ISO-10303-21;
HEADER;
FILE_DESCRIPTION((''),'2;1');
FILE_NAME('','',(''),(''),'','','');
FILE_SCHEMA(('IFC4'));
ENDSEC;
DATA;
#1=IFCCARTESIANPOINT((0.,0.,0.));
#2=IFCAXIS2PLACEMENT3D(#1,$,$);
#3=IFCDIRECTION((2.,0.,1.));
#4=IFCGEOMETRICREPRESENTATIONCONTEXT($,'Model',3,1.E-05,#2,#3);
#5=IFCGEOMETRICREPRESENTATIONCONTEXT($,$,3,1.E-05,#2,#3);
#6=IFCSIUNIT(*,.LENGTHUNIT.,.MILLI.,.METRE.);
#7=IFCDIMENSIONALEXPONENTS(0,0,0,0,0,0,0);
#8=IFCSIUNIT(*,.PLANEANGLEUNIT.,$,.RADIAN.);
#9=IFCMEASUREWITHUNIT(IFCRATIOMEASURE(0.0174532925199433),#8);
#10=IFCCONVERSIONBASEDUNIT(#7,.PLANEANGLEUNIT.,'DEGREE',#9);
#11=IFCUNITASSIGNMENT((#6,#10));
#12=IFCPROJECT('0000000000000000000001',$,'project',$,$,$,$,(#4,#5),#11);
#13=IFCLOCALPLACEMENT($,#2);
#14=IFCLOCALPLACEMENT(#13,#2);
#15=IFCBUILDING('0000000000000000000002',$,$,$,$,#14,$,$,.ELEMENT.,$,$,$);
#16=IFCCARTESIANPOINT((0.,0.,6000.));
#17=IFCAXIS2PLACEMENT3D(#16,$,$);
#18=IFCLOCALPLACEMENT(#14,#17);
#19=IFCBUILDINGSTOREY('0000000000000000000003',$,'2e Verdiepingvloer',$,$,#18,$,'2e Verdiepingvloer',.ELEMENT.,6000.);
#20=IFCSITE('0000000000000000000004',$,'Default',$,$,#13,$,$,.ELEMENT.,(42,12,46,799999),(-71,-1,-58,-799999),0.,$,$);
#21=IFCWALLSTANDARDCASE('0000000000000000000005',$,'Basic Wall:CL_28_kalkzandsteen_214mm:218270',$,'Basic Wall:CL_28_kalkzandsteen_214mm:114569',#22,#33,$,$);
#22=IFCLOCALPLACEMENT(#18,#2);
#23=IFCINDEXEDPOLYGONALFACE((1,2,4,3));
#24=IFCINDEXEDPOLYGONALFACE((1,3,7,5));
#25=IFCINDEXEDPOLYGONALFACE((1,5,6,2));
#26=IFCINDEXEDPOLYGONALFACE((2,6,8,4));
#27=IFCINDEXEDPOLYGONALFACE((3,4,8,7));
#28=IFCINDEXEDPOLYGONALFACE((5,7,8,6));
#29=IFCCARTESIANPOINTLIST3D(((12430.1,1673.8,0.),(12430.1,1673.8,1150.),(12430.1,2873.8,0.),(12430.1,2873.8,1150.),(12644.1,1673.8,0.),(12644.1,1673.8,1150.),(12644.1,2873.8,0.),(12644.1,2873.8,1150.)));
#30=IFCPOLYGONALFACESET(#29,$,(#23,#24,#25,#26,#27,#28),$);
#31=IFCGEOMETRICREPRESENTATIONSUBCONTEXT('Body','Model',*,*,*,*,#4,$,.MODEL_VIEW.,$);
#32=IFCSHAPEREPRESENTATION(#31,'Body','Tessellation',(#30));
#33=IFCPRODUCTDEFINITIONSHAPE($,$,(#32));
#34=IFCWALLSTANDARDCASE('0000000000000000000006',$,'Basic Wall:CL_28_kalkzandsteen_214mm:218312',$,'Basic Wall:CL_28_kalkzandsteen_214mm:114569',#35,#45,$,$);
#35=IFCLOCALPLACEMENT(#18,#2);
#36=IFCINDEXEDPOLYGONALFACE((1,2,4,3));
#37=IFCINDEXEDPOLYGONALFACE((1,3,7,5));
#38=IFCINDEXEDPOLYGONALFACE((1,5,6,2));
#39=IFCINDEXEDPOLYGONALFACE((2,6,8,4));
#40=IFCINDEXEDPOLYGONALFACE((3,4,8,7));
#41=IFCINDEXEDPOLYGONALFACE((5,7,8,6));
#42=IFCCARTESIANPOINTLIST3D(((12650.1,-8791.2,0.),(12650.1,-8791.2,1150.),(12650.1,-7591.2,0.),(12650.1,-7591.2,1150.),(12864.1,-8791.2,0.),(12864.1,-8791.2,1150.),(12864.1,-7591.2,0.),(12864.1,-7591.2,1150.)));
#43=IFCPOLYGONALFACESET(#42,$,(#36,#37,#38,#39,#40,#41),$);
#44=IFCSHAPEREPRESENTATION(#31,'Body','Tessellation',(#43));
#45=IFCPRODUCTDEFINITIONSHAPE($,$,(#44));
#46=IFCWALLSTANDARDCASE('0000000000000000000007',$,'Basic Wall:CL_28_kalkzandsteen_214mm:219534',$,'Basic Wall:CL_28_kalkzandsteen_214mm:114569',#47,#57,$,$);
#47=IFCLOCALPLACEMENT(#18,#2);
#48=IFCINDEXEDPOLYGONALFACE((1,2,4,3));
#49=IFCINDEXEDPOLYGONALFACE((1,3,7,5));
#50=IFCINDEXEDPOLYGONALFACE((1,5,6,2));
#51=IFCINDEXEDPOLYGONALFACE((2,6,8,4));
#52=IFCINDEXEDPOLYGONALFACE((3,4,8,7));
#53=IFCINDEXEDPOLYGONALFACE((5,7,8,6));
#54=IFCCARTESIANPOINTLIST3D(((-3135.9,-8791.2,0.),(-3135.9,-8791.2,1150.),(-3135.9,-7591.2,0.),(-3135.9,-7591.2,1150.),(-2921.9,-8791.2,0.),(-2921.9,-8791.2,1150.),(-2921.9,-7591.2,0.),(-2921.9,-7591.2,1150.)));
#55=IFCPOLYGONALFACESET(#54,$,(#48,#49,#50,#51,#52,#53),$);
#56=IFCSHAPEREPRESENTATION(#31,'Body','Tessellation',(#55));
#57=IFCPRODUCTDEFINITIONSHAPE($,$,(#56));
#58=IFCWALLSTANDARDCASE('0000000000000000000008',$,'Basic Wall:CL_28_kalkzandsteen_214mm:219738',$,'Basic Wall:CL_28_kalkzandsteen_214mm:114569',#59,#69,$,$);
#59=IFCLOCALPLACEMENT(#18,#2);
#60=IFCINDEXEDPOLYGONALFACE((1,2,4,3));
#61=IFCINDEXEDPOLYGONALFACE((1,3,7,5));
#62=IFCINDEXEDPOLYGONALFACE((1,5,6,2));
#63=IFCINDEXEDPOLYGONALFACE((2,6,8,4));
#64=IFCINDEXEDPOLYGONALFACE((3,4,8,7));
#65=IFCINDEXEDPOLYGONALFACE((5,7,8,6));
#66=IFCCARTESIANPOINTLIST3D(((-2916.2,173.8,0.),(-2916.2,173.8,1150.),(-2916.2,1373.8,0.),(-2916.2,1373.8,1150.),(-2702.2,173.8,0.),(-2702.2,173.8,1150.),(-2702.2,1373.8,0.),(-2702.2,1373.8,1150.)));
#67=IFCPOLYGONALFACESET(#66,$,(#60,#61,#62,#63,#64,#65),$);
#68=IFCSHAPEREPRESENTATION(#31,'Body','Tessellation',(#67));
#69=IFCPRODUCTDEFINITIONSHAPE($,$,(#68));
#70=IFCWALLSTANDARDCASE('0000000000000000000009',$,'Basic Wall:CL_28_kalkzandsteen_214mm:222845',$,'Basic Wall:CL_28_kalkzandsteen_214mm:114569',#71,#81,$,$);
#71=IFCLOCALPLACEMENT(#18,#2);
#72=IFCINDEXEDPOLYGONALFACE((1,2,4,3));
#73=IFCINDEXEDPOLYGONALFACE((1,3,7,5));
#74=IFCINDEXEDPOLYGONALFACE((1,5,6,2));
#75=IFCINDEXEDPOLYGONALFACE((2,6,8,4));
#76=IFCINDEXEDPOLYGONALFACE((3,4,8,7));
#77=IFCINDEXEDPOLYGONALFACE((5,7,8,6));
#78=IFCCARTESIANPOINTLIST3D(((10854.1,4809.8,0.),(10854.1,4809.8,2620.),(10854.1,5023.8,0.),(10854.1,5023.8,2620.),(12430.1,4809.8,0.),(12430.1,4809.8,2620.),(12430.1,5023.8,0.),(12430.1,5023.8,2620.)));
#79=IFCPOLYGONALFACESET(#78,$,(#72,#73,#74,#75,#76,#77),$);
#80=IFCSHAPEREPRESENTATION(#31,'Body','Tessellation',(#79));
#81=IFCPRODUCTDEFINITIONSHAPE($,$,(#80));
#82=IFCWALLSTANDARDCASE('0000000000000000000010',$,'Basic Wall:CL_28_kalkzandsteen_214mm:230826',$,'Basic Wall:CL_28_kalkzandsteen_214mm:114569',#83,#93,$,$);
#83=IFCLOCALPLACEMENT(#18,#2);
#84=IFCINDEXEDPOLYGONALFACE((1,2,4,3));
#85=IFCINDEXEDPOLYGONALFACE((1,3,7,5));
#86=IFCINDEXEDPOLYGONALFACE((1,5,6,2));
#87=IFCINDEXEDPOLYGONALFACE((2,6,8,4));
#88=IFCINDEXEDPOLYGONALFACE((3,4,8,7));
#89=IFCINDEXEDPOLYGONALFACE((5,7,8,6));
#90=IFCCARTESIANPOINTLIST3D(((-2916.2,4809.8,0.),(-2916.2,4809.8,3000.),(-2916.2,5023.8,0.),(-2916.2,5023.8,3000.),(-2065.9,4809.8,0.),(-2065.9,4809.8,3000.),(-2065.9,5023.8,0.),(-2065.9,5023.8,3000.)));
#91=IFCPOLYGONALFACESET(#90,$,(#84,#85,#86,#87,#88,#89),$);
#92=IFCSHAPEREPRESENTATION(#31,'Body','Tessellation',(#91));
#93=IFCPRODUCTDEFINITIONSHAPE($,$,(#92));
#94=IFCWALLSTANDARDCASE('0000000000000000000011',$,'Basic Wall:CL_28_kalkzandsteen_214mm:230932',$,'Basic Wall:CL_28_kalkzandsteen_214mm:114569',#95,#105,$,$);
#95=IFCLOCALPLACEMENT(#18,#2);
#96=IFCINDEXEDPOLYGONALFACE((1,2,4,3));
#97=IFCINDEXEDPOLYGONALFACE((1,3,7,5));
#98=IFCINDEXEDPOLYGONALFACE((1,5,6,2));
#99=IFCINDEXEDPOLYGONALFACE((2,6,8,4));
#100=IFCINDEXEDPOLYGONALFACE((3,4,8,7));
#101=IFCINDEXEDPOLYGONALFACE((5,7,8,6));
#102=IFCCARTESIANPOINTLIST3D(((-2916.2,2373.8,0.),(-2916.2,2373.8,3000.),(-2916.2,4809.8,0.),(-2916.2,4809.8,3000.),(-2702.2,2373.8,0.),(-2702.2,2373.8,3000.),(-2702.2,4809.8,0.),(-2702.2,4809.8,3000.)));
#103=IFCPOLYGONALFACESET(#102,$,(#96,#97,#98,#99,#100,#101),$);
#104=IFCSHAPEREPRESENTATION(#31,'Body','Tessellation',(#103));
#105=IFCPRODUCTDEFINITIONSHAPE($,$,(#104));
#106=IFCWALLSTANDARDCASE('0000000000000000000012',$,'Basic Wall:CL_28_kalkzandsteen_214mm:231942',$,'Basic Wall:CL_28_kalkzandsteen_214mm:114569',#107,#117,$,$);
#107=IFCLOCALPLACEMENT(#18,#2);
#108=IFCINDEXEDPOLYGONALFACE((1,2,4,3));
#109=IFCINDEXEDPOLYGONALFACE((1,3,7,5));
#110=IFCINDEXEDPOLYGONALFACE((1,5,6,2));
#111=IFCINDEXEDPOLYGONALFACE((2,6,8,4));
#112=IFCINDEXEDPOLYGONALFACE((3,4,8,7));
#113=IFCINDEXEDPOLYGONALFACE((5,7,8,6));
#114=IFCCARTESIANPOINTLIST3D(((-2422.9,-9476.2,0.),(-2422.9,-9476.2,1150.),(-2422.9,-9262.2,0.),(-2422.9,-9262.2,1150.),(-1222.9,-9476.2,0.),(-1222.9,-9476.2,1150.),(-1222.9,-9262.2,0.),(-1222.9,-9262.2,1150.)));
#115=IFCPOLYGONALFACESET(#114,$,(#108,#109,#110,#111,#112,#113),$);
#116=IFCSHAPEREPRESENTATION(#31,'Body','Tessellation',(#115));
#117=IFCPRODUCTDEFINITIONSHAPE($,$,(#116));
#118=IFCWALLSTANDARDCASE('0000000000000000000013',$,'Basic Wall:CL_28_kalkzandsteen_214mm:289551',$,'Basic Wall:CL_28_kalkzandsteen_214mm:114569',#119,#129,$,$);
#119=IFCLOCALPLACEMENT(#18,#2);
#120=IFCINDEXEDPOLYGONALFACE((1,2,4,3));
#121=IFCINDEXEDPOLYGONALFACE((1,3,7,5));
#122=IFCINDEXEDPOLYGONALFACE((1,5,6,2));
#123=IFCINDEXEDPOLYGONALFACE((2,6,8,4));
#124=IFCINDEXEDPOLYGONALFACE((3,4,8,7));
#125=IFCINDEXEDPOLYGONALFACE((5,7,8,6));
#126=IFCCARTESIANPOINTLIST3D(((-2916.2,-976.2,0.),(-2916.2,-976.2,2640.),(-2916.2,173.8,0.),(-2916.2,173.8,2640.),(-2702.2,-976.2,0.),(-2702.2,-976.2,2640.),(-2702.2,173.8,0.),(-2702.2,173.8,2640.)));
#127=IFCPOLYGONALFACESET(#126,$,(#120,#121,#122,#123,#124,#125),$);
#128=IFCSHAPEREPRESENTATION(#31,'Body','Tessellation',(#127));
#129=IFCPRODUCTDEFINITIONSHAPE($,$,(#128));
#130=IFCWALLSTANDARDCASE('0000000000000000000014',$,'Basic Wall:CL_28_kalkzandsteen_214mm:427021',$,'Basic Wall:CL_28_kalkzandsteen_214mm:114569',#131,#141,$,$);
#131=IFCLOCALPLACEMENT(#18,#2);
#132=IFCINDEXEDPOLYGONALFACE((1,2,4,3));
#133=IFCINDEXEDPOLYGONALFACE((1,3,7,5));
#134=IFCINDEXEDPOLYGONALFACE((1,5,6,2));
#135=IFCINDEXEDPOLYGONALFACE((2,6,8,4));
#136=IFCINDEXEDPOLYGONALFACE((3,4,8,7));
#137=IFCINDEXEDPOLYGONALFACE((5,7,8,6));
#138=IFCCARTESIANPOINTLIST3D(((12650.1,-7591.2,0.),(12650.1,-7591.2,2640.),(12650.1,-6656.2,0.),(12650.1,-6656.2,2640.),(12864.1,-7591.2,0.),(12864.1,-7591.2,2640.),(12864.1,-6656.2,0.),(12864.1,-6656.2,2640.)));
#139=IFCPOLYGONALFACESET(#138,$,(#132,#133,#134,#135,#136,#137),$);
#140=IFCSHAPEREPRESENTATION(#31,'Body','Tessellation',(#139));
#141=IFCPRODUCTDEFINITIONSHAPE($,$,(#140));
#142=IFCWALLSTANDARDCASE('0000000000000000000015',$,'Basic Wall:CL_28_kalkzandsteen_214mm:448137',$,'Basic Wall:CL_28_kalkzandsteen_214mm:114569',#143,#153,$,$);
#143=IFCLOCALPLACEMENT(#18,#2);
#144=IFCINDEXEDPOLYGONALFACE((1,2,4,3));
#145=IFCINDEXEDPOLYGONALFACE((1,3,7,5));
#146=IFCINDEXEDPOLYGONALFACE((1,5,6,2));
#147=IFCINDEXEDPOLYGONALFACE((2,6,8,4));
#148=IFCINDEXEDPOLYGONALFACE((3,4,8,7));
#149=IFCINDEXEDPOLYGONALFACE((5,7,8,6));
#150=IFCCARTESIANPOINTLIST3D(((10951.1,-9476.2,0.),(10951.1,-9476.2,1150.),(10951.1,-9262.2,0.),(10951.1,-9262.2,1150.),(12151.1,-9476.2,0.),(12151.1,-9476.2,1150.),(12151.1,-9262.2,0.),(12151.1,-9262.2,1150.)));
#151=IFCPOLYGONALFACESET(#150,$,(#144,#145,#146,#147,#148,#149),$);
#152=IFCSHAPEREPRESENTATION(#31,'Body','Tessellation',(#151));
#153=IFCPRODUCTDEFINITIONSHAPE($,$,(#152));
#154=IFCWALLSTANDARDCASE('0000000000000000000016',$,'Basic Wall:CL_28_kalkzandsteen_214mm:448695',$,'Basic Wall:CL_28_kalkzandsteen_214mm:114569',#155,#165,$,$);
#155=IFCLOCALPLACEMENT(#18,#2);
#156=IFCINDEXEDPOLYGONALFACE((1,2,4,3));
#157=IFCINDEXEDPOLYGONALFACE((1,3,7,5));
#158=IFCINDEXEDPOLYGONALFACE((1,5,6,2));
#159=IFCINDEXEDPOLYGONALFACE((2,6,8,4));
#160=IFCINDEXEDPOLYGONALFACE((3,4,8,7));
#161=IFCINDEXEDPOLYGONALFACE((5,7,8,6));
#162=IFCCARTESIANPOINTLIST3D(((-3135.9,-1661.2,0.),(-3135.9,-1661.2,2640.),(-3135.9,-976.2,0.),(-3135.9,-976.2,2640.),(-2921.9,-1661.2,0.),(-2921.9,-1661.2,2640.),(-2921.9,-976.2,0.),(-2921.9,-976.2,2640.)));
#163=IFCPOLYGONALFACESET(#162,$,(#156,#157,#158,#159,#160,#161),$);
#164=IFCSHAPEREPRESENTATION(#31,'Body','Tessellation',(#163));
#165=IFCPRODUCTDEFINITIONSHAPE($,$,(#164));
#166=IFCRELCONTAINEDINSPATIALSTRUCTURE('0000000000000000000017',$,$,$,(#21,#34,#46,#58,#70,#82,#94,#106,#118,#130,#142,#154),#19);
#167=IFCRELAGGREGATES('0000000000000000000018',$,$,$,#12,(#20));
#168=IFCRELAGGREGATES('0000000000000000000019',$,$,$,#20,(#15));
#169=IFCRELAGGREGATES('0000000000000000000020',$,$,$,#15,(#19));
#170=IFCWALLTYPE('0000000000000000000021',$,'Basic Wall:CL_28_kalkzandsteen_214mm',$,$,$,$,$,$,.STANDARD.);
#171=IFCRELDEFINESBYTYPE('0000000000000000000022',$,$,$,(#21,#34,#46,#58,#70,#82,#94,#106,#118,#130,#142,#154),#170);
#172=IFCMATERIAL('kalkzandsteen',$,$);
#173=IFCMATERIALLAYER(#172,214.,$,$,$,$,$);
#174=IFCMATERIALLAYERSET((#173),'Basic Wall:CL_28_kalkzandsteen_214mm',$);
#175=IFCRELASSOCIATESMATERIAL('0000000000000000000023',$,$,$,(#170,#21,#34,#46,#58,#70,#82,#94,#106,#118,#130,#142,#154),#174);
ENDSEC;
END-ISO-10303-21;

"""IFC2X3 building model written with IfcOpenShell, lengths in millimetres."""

from ifc_helpers import new_model, entity, si_unit, converted_unit, direction, frame, frame_2d, origin, place, context, subcontext, project, spatial, polyline, rectangle, extrude, clip, bounded_halfspace, material, layer, layer_set, layer_usage, type_object, element, save


model = new_model("IFC2X3")

# Units and contexts
model_context = context("Model", 3, precision=1e-05, world=origin(), true_north=direction((2.0, 0.0, 1.0)))
context_of_model = context(None, 3, precision=1e-05, world=origin(), true_north=direction((2.0, 0.0, 1.0)))
body_context = subcontext(model_context, "Body", "Model", "MODEL_VIEW")
ifc_project = project(units=[si_unit("LENGTHUNIT", "METRE", prefix="MILLI"), converted_unit("PLANEANGLEUNIT", "DEGREE", entity("IfcRatioMeasure", 0.0174532925199433), si_unit("PLANEANGLEUNIT", "RADIAN"), dimensions=[0, 0, 0, 0, 0, 0, 0])], contexts=[model_context, context_of_model])

# Site, building, storey
site_placement = place(None, origin())
site = spatial("IfcSite", under=ifc_project, at=site_placement, Name="Default", CompositionType="ELEMENT", RefLatitude=(42, 12, 46, 799999), RefLongitude=(-71, -1, -58, -799999), RefElevation=0.0)
building_placement = place(site_placement, origin())
building = spatial("IfcBuilding", under=site, at=building_placement, CompositionType="ELEMENT")
storey_placement = place(building_placement, frame((0.0, 0.0, 6000.0)))
storey = spatial("IfcBuildingStorey", under=building, at=storey_placement, Name="2e Verdiepingvloer", LongName="2e Verdiepingvloer", CompositionType="ELEMENT", Elevation=6000.0)

# Walls
ifc_material_1 = material(Name="kalkzandsteen")
ifc_layer_1 = layer(ifc_material_1, 214.0)
ifc_layer_set_1 = layer_set([ifc_layer_1], Name="Basic Wall:CL_28_kalkzandsteen_214mm")
ifc_layer_usage_1 = layer_usage(ifc_layer_set_1, "AXIS2", "NEGATIVE", 107.0)
wall_type_1 = type_object("IfcWallType", Name="Basic Wall:CL_28_kalkzandsteen_214mm", PredefinedType="STANDARD", material=ifc_layer_set_1)
wall_1_placement = place(storey_placement, frame((12537.1, 1673.8, 0.0), z_axis=(0.0, 0.0, 1.0), x_axis=(0.0, 1.0, 0.0)))
element("IfcWallStandardCase", 1, at=wall_1_placement, inside=storey, type_object=wall_type_1, material=ifc_layer_usage_1, Name="Basic Wall:CL_28_kalkzandsteen_214mm:218270", ObjectType="Basic Wall:CL_28_kalkzandsteen_214mm:114569", context=body_context, shape_type="SweptSolid", body=[
    extrude(rectangle(XDim=1200.0, YDim=214.0, at=frame_2d((600.0, 0.0), x_axis=(-1.0, 0.0))), origin(), (0.0, 0.0, 1.0), 1150.0),
])
ifc_layer_usage_2 = layer_usage(ifc_layer_set_1, "AXIS2", "NEGATIVE", 107.0)
wall_2_placement = place(storey_placement, frame((12757.1, -8791.2, 0.0), z_axis=(0.0, 0.0, 1.0), x_axis=(0.0, 1.0, 0.0)))
element("IfcWallStandardCase", 2, at=wall_2_placement, inside=storey, type_object=wall_type_1, material=ifc_layer_usage_2, Name="Basic Wall:CL_28_kalkzandsteen_214mm:218312", ObjectType="Basic Wall:CL_28_kalkzandsteen_214mm:114569", context=body_context, shape_type="SweptSolid", body=[
    extrude(rectangle(XDim=1200.0, YDim=214.0, at=frame_2d((600.0, 0.0), x_axis=(-1.0, 0.0))), origin(), (0.0, 0.0, 1.0), 1150.0),
])
ifc_layer_usage_3 = layer_usage(ifc_layer_set_1, "AXIS2", "NEGATIVE", 107.0)
wall_3_placement = place(storey_placement, frame((-3028.9, -7591.2, 0.0), z_axis=(0.0, 0.0, 1.0), x_axis=(0.0, -1.0, 0.0)))
element("IfcWallStandardCase", 3, at=wall_3_placement, inside=storey, type_object=wall_type_1, material=ifc_layer_usage_3, Name="Basic Wall:CL_28_kalkzandsteen_214mm:219534", ObjectType="Basic Wall:CL_28_kalkzandsteen_214mm:114569", context=body_context, shape_type="SweptSolid", body=[
    extrude(rectangle(XDim=1200.0, YDim=214.0, at=frame_2d((600.0, 0.0), x_axis=(-1.0, 0.0))), origin(), (0.0, 0.0, 1.0), 1150.0),
])
ifc_layer_usage_4 = layer_usage(ifc_layer_set_1, "AXIS2", "NEGATIVE", 107.0)
wall_4_placement = place(storey_placement, frame((-2809.2, 1373.8, 0.0), z_axis=(0.0, 0.0, 1.0), x_axis=(0.0, -1.0, 0.0)))
element("IfcWallStandardCase", 4, at=wall_4_placement, inside=storey, type_object=wall_type_1, material=ifc_layer_usage_4, Name="Basic Wall:CL_28_kalkzandsteen_214mm:219738", ObjectType="Basic Wall:CL_28_kalkzandsteen_214mm:114569", context=body_context, shape_type="SweptSolid", body=[
    extrude(rectangle(XDim=1200.0, YDim=214.0, at=frame_2d((600.0, 0.0), x_axis=(-1.0, 0.0))), origin(), (0.0, 0.0, 1.0), 1150.0),
])
ifc_layer_usage_5 = layer_usage(ifc_layer_set_1, "AXIS2", "NEGATIVE", 107.0)
wall_5_placement = place(storey_placement, frame((12430.1, 4916.8, 0.0), z_axis=(0.0, 0.0, 1.0), x_axis=(-1.0, 0.0, 0.0)))
element("IfcWallStandardCase", 5, at=wall_5_placement, inside=storey, type_object=wall_type_1, material=ifc_layer_usage_5, Name="Basic Wall:CL_28_kalkzandsteen_214mm:222845", ObjectType="Basic Wall:CL_28_kalkzandsteen_214mm:114569", context=body_context, shape_type="Clipping", body=[
    clip(extrude(rectangle(XDim=1576.0, YDim=214.0, at=frame_2d((788.0, 0.0), x_axis=(-1.0, 0.0))), origin(), (0.0, 0.0, 1.0), 2620.0), bounded_halfspace(frame((0.0, -107.0, 2620.0), z_axis=(0.0, 0.0, -1.0), x_axis=(-1.0, 0.0, 0.0)), True, frame((0.0, -107.0, 2620.0)), polyline([(0.0, 0.0), (1576.0, 0.0), (1576.0, 214.0), (0.0, 214.0), (0.0, 0.0)]))),
])
ifc_layer_usage_6 = layer_usage(ifc_layer_set_1, "AXIS2", "NEGATIVE", 107.0)
wall_6_placement = place(storey_placement, frame((-2065.9, 4916.8, 0.0), z_axis=(0.0, 0.0, 1.0), x_axis=(-1.0, 0.0, 0.0)))
element("IfcWallStandardCase", 6, at=wall_6_placement, inside=storey, type_object=wall_type_1, material=ifc_layer_usage_6, Name="Basic Wall:CL_28_kalkzandsteen_214mm:230826", ObjectType="Basic Wall:CL_28_kalkzandsteen_214mm:114569", context=body_context, shape_type="SweptSolid", body=[
    extrude(rectangle(XDim=850.3, YDim=214.0, at=frame_2d((425.1, 0.0), x_axis=(-1.0, 0.0))), origin(), (0.0, 0.0, 1.0), 3000.0),
])
ifc_layer_usage_7 = layer_usage(ifc_layer_set_1, "AXIS2", "NEGATIVE", 107.0)
wall_7_placement = place(storey_placement, frame((-2809.2, 4809.8, 0.0), z_axis=(0.0, 0.0, 1.0), x_axis=(0.0, -1.0, 0.0)))
element("IfcWallStandardCase", 7, at=wall_7_placement, inside=storey, type_object=wall_type_1, material=ifc_layer_usage_7, Name="Basic Wall:CL_28_kalkzandsteen_214mm:230932", ObjectType="Basic Wall:CL_28_kalkzandsteen_214mm:114569", context=body_context, shape_type="SweptSolid", body=[
    extrude(rectangle(XDim=2436.0, YDim=214.0, at=frame_2d((1218.0, 0.0), x_axis=(-1.0, 0.0))), origin(), (0.0, 0.0, 1.0), 3000.0),
])
ifc_layer_usage_8 = layer_usage(ifc_layer_set_1, "AXIS2", "NEGATIVE", 107.0)
wall_8_placement = place(storey_placement, frame((-2422.9, -9369.2, 0.0)))
element("IfcWallStandardCase", 8, at=wall_8_placement, inside=storey, type_object=wall_type_1, material=ifc_layer_usage_8, Name="Basic Wall:CL_28_kalkzandsteen_214mm:231942", ObjectType="Basic Wall:CL_28_kalkzandsteen_214mm:114569", context=body_context, shape_type="SweptSolid", body=[
    extrude(rectangle(XDim=1200.0, YDim=214.0, at=frame_2d((600.0, 0.0), x_axis=(-1.0, 0.0))), origin(), (0.0, 0.0, 1.0), 1150.0),
])
ifc_layer_usage_9 = layer_usage(ifc_layer_set_1, "AXIS2", "NEGATIVE", 107.0)
wall_9_placement = place(storey_placement, frame((-2809.2, 173.8, 0.0), z_axis=(0.0, 0.0, 1.0), x_axis=(0.0, -1.0, 0.0)))
element("IfcWallStandardCase", 9, at=wall_9_placement, inside=storey, type_object=wall_type_1, material=ifc_layer_usage_9, Name="Basic Wall:CL_28_kalkzandsteen_214mm:289551", ObjectType="Basic Wall:CL_28_kalkzandsteen_214mm:114569", context=body_context, shape_type="SweptSolid", body=[
    extrude(rectangle(XDim=1150.0, YDim=214.0, at=frame_2d((575.0, 0.0), x_axis=(-1.0, 0.0))), origin(), (0.0, 0.0, 1.0), 2640.0),
])
ifc_layer_usage_10 = layer_usage(ifc_layer_set_1, "AXIS2", "NEGATIVE", 107.0)
wall_10_placement = place(storey_placement, frame((12757.1, -7591.2, 0.0), z_axis=(0.0, 0.0, 1.0), x_axis=(0.0, 1.0, 0.0)))
element("IfcWallStandardCase", 10, at=wall_10_placement, inside=storey, type_object=wall_type_1, material=ifc_layer_usage_10, Name="Basic Wall:CL_28_kalkzandsteen_214mm:427021", ObjectType="Basic Wall:CL_28_kalkzandsteen_214mm:114569", context=body_context, shape_type="SweptSolid", body=[
    extrude(rectangle(XDim=935.0, YDim=214.0, at=frame_2d((467.5, 0.0), x_axis=(-1.0, 0.0))), origin(), (0.0, 0.0, 1.0), 2640.0),
])
ifc_layer_usage_11 = layer_usage(ifc_layer_set_1, "AXIS2", "NEGATIVE", 107.0)
wall_11_placement = place(storey_placement, frame((10951.1, -9369.2, 0.0)))
element("IfcWallStandardCase", 11, at=wall_11_placement, inside=storey, type_object=wall_type_1, material=ifc_layer_usage_11, Name="Basic Wall:CL_28_kalkzandsteen_214mm:448137", ObjectType="Basic Wall:CL_28_kalkzandsteen_214mm:114569", context=body_context, shape_type="SweptSolid", body=[
    extrude(rectangle(XDim=1200.0, YDim=214.0, at=frame_2d((600.0, 0.0), x_axis=(-1.0, 0.0))), origin(), (0.0, 0.0, 1.0), 1150.0),
])
ifc_layer_usage_12 = layer_usage(ifc_layer_set_1, "AXIS2", "NEGATIVE", 107.0)
wall_12_placement = place(storey_placement, frame((-3028.9, -976.2, 0.0), z_axis=(0.0, 0.0, 1.0), x_axis=(0.0, -1.0, 0.0)))
element("IfcWallStandardCase", 12, at=wall_12_placement, inside=storey, type_object=wall_type_1, material=ifc_layer_usage_12, Name="Basic Wall:CL_28_kalkzandsteen_214mm:448695", ObjectType="Basic Wall:CL_28_kalkzandsteen_214mm:114569", context=body_context, shape_type="SweptSolid", body=[
    extrude(rectangle(XDim=685.0, YDim=214.0, at=frame_2d((342.5, 0.0), x_axis=(-1.0, 0.0))), origin(), (0.0, 0.0, 1.0), 2640.0),
])

save(model, "model.ifc")
